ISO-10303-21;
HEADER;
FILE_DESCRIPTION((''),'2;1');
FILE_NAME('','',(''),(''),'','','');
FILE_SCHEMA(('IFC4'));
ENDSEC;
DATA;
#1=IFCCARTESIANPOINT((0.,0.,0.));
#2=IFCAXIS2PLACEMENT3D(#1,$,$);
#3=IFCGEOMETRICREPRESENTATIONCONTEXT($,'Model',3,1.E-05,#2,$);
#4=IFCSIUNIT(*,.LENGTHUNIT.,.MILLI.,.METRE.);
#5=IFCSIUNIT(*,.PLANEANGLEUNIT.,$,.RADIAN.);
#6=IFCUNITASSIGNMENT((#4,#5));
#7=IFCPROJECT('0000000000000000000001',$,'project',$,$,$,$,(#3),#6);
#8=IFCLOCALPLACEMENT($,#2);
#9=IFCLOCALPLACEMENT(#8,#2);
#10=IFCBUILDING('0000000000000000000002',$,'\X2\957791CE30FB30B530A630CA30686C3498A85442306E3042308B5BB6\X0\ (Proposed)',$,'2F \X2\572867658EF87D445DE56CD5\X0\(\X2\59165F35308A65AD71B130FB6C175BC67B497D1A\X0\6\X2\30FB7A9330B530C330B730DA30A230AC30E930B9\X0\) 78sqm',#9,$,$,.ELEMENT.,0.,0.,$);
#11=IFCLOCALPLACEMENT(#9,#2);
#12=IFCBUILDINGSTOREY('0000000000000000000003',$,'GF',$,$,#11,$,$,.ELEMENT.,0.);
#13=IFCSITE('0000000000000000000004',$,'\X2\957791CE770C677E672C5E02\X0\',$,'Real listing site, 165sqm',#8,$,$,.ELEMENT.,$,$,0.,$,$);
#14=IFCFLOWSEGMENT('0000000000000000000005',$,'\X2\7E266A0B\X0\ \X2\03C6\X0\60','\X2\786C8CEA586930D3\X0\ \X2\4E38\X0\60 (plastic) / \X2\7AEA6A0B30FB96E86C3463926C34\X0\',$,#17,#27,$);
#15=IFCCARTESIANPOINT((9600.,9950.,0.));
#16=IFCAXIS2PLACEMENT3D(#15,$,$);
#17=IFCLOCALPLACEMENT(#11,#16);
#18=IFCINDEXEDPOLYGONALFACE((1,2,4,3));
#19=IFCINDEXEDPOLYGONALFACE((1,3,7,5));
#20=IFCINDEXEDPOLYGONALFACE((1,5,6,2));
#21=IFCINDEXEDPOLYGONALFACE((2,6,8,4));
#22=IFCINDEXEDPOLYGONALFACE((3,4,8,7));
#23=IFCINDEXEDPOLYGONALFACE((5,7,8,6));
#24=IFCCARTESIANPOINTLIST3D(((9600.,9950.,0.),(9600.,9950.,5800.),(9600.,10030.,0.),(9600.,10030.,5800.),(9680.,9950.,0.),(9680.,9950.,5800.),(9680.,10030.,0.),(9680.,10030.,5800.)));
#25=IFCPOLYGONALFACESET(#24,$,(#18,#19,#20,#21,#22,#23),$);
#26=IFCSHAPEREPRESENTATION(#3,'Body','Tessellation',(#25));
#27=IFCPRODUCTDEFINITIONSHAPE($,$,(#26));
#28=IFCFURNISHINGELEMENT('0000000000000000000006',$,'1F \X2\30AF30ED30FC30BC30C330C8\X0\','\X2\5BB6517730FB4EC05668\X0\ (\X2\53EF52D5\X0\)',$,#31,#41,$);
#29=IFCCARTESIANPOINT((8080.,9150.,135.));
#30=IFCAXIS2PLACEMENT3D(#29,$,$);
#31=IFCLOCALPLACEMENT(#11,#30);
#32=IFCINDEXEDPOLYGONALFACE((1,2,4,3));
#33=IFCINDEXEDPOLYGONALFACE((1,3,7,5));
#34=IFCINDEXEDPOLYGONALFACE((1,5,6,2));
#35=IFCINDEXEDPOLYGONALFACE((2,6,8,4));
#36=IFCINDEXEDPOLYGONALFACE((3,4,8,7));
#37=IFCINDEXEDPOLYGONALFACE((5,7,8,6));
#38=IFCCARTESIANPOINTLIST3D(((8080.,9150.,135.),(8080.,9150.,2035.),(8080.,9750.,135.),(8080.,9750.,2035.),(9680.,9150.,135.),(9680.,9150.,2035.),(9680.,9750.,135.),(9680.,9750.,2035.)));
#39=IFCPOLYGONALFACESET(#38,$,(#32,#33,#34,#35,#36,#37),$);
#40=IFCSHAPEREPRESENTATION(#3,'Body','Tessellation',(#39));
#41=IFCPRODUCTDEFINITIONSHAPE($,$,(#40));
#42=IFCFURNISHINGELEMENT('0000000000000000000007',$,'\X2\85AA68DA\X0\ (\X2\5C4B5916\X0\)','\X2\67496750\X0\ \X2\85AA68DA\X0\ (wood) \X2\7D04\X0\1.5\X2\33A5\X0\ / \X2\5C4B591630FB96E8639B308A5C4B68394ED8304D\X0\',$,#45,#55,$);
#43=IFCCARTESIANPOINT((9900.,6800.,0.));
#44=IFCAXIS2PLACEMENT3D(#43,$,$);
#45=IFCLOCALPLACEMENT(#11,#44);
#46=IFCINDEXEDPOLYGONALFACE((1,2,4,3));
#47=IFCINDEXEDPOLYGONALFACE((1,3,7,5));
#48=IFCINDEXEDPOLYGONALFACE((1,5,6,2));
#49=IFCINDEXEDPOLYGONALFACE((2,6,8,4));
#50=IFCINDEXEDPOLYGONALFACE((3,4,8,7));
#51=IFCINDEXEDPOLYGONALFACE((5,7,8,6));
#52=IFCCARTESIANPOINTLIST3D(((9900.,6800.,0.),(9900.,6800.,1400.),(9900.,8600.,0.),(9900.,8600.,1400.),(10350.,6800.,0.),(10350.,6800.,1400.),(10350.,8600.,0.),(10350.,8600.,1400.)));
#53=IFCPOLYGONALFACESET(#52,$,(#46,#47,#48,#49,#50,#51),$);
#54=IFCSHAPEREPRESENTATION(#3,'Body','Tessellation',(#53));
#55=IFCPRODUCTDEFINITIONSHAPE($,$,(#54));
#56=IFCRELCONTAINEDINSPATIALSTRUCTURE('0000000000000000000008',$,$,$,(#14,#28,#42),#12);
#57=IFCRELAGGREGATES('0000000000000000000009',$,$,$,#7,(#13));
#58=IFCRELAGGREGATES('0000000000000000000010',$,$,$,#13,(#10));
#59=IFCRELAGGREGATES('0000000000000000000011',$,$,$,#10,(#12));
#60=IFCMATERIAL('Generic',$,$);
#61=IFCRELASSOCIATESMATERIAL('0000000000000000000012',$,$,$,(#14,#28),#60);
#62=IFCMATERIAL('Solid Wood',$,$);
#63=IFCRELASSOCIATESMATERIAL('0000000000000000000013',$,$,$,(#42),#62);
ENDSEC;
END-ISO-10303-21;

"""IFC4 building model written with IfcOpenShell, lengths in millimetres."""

from ifc_helpers import new_model, si_unit, frame, frame_2d, origin, place, context, project, spatial, rectangle, extrude, material, element, save


model = new_model("IFC4")

# Units and contexts
model_context = context("Model", 3, precision=1e-05, world=origin())
ifc_project = project(units=[si_unit("LENGTHUNIT", "METRE", prefix="MILLI"), si_unit("PLANEANGLEUNIT", "RADIAN")], contexts=[model_context])

# Site, building, storey
site_placement = place(None, origin())
site = spatial("IfcSite", under=ifc_project, at=site_placement, Name="長野県松本市", ObjectType="Real listing site, 165sqm", CompositionType="ELEMENT", RefElevation=0.0)
building_placement = place(site_placement, origin())
building = spatial("IfcBuilding", under=site, at=building_placement, Name="長野・サウナと水風呂のある家 (Proposed)", ObjectType="2F 在来軸組工法(外張り断熱・気密等級6・窓サッシペアガラス) 78sqm", CompositionType="ELEMENT", ElevationOfRefHeight=0.0, ElevationOfTerrain=0.0)
storey_placement = place(building_placement, origin())
storey = spatial("IfcBuildingStorey", under=building, at=storey_placement, Name="GF", CompositionType="ELEMENT", Elevation=0.0)

# Shared definitions
ifc_material_1 = material(Name="Solid Wood")

# Shared definitions
ifc_material_2 = material(Name="Generic")

# Flow segment
flow_segment_placement = place(storey_placement, frame((9600.0, 9950.0, 0.0)))
element("IfcFlowSegment", 1, at=flow_segment_placement, inside=storey, material=ifc_material_2, Name="縦樋 φ60", Description="硬質塩ビ 丸60 (plastic) / 竪樋・雨水排水", context=model_context, shape_type="SweptSolid", body=[
    extrude(rectangle(XDim=80.0, YDim=80.0, at=frame_2d((40.0, 40.0))), frame((9600.0, 9950.0, 0.0)), (0.0, 0.0, 1.0), 5800.0),
])

# Furnishing elements
furnishing_1_placement = place(storey_placement, frame((8080.0, 9150.0, 135.0)))
element("IfcFurnishingElement", 2, at=furnishing_1_placement, inside=storey, material=ifc_material_2, Name="1F クローゼット", Description="家具・什器 (可動)", context=model_context, shape_type="SweptSolid", body=[
    extrude(rectangle(XDim=1600.0, YDim=600.0, at=frame_2d((800.0, 300.0))), frame((8080.0, 9150.0, 135.0)), (0.0, 0.0, 1.0), 1900.0),
])
furnishing_2_placement = place(storey_placement, frame((9900.0, 6800.0, 0.0)))
element("IfcFurnishingElement", 3, at=furnishing_2_placement, inside=storey, material=ifc_material_1, Name="薪棚 (屋外)", Description="杉材 薪棚 (wood) 約1.5㎥ / 屋外・雨掛り屋根付き", context=model_context, shape_type="SweptSolid", body=[
    extrude(rectangle(XDim=450.0, YDim=1800.0, at=frame_2d((225.0, 900.0))), frame((9900.0, 6800.0, 0.0)), (0.0, 0.0, 1.0), 1400.0),
])

save(model, "model.ifc")
